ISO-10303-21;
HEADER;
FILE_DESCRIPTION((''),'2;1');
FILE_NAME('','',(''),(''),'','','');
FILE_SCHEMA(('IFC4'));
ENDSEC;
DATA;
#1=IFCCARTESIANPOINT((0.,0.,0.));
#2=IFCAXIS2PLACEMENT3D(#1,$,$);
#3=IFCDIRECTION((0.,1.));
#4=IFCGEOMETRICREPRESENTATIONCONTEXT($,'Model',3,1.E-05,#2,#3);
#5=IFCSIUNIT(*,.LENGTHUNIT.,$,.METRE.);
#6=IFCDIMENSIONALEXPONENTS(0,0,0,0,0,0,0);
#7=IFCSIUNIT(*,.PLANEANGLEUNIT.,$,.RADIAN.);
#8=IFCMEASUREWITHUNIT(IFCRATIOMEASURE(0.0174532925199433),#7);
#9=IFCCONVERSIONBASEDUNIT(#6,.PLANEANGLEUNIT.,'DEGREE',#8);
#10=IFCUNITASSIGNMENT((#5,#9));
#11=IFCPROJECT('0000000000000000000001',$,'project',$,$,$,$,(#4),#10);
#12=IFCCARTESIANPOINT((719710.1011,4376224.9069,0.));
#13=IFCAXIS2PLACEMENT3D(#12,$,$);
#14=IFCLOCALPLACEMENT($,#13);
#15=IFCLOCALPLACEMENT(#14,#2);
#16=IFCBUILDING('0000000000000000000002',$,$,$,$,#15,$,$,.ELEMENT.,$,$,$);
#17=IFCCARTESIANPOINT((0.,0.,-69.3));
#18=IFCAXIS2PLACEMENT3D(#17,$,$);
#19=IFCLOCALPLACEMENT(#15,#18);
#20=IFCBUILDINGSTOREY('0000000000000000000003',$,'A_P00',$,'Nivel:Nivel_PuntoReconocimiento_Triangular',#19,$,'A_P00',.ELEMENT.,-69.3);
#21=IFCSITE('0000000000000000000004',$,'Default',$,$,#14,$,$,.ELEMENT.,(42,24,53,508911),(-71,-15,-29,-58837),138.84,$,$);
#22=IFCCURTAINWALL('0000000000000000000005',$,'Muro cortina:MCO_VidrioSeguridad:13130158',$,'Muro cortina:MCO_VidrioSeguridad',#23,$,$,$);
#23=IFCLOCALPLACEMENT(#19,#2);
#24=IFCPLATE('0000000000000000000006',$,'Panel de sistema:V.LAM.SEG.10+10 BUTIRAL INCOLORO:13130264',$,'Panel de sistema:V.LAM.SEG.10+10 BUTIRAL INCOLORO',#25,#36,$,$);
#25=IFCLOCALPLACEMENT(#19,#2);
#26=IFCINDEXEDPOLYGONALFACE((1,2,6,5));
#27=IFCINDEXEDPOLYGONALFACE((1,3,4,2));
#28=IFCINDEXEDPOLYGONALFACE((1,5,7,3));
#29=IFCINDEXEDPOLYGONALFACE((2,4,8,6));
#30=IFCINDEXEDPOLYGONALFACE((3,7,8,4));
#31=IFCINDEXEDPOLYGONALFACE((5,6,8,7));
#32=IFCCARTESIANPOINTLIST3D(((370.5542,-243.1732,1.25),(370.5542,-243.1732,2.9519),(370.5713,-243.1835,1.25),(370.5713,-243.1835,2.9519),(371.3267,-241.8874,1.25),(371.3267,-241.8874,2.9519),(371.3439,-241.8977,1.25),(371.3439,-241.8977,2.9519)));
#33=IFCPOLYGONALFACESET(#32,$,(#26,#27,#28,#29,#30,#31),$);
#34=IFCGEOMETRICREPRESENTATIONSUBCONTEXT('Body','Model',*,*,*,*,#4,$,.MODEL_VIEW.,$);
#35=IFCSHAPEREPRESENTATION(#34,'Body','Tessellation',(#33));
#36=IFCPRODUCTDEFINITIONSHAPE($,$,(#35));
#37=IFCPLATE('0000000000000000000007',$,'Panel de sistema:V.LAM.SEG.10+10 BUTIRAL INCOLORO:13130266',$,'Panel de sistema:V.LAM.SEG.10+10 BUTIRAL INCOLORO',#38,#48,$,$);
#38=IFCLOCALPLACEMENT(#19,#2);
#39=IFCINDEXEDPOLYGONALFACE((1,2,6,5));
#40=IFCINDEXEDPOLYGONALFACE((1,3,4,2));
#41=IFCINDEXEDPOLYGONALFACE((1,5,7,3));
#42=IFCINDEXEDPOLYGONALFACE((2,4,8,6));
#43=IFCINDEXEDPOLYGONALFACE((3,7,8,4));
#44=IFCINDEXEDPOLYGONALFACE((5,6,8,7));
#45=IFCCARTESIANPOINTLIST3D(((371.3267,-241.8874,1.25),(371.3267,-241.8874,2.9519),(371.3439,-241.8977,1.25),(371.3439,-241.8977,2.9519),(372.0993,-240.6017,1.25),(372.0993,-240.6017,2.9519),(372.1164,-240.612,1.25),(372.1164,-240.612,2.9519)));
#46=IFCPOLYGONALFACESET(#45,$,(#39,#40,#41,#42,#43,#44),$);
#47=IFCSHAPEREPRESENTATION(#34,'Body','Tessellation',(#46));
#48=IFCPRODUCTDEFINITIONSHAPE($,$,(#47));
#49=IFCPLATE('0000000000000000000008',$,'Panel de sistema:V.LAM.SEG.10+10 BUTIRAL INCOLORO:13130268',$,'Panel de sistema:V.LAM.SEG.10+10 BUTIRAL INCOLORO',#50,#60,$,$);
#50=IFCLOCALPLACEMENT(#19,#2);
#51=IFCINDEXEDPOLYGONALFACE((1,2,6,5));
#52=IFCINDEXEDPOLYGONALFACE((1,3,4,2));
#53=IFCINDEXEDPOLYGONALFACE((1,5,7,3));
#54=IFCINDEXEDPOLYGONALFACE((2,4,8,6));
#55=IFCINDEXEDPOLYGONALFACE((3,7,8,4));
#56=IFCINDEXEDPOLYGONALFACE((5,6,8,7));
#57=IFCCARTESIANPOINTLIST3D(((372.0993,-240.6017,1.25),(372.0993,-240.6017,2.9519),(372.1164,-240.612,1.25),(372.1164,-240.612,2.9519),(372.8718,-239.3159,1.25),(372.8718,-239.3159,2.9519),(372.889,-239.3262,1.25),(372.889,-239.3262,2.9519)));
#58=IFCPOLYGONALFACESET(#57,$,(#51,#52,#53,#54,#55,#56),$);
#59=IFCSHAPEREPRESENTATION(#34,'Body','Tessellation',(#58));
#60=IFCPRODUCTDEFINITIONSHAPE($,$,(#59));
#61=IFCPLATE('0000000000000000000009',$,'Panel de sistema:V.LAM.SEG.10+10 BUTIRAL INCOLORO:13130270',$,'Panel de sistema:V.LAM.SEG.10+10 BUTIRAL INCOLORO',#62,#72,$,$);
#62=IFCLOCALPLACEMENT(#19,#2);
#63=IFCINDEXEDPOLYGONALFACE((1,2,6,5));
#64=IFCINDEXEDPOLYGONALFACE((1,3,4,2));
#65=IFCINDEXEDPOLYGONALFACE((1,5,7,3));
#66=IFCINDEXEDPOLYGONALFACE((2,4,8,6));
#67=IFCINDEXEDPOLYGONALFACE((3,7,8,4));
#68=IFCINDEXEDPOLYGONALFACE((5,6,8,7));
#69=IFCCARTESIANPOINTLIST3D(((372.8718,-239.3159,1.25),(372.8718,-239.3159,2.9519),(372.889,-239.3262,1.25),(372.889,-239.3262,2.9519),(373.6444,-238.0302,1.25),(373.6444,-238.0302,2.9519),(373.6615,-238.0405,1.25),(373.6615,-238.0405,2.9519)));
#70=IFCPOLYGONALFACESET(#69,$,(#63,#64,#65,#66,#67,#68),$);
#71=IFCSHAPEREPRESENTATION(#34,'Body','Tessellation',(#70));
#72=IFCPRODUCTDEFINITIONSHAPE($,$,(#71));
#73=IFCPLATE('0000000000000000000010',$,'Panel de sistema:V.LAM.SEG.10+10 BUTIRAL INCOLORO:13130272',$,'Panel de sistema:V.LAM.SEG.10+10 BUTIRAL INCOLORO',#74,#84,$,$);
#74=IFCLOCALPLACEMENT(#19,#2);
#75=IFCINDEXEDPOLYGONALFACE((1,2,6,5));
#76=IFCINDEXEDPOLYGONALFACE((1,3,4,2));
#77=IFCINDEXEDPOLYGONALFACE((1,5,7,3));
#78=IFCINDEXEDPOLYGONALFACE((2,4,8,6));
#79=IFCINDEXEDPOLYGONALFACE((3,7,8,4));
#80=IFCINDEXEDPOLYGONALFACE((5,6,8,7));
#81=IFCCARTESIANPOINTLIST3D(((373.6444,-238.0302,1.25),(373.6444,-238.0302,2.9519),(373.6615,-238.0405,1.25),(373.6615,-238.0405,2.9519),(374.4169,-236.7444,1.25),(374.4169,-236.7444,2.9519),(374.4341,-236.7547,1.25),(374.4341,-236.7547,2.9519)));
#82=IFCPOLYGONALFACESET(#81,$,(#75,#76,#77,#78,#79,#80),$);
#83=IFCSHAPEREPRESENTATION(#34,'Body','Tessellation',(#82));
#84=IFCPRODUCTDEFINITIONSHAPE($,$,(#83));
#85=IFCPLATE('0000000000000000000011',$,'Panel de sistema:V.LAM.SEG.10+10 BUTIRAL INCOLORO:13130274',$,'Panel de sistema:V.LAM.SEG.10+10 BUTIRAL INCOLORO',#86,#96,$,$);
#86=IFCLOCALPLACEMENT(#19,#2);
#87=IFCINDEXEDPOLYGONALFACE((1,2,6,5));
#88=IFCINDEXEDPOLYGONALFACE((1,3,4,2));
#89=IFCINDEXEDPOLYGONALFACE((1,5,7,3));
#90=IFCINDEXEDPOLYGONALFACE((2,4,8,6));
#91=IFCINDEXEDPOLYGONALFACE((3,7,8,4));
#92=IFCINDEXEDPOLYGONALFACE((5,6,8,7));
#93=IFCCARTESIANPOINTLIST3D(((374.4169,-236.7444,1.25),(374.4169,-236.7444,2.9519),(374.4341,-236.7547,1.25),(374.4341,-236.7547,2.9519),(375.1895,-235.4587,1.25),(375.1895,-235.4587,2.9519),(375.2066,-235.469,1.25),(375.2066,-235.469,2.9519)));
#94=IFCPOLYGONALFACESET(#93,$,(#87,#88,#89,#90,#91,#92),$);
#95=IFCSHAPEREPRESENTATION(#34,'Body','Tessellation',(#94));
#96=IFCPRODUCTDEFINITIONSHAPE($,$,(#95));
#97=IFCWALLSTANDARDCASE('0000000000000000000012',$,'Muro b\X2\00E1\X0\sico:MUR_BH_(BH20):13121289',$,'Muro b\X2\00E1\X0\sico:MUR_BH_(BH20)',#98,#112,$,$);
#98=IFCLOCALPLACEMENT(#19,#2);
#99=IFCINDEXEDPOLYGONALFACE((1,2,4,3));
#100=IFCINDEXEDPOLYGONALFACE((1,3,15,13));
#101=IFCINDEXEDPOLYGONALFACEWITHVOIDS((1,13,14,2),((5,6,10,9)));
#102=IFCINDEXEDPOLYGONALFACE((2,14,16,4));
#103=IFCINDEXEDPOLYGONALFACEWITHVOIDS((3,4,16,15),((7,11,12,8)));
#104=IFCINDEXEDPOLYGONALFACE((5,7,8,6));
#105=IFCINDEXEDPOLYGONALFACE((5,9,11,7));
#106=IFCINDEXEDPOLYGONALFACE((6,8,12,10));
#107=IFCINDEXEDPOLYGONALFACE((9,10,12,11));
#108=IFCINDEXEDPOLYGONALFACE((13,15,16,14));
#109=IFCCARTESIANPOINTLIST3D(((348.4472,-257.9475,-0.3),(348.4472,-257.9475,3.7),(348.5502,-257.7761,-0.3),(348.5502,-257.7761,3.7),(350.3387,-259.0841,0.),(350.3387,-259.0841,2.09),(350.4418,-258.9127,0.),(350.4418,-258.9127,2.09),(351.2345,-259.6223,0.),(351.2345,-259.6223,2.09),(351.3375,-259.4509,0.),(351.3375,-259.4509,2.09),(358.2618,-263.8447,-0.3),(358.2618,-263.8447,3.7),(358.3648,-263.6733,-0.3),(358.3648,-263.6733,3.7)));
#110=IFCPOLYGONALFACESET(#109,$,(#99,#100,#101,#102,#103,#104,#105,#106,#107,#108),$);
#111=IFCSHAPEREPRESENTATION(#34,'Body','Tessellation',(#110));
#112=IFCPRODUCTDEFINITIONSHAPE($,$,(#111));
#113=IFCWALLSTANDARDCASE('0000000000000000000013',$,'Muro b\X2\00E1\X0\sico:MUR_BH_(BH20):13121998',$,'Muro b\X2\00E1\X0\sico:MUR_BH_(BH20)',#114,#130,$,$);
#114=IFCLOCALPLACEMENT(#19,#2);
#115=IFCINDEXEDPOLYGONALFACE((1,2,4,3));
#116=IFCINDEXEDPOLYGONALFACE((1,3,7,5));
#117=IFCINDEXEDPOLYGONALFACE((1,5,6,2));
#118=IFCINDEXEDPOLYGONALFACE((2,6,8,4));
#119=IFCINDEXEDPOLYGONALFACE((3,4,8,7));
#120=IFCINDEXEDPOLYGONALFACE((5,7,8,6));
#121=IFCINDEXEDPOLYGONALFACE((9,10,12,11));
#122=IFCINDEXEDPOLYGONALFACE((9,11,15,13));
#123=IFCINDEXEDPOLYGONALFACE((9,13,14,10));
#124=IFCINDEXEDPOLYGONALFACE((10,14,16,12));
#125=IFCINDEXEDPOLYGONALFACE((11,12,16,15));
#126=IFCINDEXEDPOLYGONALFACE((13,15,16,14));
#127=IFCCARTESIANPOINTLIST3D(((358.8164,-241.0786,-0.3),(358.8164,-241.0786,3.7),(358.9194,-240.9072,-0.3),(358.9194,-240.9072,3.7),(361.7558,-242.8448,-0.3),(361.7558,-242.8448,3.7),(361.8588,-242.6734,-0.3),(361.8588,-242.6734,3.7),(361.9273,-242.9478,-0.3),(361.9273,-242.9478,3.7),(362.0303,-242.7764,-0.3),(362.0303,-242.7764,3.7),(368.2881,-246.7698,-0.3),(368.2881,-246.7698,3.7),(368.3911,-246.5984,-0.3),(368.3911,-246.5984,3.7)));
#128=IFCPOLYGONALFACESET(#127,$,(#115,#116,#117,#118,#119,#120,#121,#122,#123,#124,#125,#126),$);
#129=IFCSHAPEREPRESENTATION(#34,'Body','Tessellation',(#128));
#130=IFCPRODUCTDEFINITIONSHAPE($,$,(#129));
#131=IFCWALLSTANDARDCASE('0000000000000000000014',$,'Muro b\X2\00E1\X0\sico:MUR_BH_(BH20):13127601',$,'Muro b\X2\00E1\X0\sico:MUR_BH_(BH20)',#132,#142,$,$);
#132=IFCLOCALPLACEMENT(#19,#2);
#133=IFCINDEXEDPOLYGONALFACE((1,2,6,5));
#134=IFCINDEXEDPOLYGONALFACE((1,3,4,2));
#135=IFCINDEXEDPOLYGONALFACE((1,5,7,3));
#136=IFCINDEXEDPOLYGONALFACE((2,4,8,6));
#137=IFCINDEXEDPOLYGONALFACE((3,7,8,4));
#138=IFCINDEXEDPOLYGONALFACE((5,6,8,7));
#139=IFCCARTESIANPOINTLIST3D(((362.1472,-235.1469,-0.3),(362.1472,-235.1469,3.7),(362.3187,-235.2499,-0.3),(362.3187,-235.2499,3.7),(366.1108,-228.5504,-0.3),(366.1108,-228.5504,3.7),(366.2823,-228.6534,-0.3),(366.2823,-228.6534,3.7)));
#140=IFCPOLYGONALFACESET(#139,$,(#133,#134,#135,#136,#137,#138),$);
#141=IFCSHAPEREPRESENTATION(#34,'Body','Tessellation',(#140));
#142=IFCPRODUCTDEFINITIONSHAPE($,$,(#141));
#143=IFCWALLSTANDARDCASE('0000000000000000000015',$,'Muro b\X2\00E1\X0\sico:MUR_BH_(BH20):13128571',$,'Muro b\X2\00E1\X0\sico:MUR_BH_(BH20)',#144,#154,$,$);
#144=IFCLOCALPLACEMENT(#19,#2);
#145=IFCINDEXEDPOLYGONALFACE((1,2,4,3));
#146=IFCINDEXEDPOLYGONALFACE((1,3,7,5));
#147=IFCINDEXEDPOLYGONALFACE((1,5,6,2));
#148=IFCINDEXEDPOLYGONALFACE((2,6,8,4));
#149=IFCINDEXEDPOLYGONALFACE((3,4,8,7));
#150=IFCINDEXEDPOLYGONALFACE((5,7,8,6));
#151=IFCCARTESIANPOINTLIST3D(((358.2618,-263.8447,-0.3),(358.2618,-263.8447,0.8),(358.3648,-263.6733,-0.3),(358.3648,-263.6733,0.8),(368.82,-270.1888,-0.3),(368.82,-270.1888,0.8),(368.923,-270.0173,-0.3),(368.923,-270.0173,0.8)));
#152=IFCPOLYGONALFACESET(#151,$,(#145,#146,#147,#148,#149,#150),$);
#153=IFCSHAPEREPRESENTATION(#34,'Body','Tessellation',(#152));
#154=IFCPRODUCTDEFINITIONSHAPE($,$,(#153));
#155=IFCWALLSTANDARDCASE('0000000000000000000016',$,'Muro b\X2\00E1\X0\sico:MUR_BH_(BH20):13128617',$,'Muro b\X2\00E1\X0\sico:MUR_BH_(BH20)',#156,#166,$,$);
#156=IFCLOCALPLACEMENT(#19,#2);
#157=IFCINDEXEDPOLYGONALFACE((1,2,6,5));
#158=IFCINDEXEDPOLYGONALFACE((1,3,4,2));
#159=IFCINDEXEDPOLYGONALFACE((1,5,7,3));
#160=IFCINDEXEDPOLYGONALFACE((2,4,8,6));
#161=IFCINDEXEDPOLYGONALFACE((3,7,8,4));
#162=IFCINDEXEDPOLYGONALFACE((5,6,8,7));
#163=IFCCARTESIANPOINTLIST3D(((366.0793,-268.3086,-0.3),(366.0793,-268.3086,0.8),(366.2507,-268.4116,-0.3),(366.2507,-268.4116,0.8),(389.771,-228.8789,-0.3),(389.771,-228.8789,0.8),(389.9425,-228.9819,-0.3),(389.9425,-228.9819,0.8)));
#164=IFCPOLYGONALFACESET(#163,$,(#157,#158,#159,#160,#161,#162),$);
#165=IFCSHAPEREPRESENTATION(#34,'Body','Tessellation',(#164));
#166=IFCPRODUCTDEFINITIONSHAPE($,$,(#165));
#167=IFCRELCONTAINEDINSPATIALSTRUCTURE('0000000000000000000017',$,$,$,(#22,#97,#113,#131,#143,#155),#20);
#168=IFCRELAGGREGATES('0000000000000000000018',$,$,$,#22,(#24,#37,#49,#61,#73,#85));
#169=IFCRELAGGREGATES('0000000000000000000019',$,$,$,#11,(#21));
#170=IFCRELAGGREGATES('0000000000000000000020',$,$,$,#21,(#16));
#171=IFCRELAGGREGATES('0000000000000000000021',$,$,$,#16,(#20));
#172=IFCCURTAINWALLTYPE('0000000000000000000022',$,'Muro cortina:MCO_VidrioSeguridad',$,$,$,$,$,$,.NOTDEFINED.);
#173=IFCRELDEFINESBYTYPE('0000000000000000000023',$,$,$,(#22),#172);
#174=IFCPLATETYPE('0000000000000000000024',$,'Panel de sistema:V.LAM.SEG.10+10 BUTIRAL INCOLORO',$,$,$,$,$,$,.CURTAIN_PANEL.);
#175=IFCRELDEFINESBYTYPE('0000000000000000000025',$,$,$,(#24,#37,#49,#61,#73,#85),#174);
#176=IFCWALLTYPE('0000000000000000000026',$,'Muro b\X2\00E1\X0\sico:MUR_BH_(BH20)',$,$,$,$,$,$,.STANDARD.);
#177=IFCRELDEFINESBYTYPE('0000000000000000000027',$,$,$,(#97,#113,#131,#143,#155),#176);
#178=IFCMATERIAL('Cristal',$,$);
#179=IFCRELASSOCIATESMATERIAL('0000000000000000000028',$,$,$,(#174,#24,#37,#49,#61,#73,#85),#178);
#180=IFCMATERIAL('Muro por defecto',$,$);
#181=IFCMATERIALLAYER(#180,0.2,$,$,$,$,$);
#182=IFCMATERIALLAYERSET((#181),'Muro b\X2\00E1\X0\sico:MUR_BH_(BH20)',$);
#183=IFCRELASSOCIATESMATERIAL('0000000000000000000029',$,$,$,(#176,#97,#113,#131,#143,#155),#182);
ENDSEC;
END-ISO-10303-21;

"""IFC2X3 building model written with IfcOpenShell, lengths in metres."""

from ifc_helpers import new_model, entity, si_unit, converted_unit, direction, frame, frame_2d, origin, place, context, subcontext, project, spatial, rectangle, extrude, source, transform, mapped, material, layer, layer_set, layer_usage, type_object, type_shapes, element, aggregate, save


model = new_model("IFC2X3")

# Units and contexts
model_context = context("Model", 3, precision=1e-05, world=origin(), true_north=direction((0.0, 1.0)))
body_context = subcontext(model_context, "Body", "Model", "MODEL_VIEW")
ifc_project = project(units=[si_unit("LENGTHUNIT", "METRE"), converted_unit("PLANEANGLEUNIT", "DEGREE", entity("IfcRatioMeasure", 0.0174532925199433), si_unit("PLANEANGLEUNIT", "RADIAN"), dimensions=[0, 0, 0, 0, 0, 0, 0])], contexts=[model_context])

# Site, building, storey
site_placement = place(None, frame((719710.1011, 4376224.9069, 0.0)))
site = spatial("IfcSite", under=ifc_project, at=site_placement, Name="Default", CompositionType="ELEMENT", RefLatitude=(42, 24, 53, 508911), RefLongitude=(-71, -15, -29, -58837), RefElevation=138.84)
building_placement = place(site_placement, origin())
building = spatial("IfcBuilding", under=site, at=building_placement, CompositionType="ELEMENT")
storey_placement = place(building_placement, frame((0.0, 0.0, -69.3)))
storey = spatial("IfcBuildingStorey", under=building, at=storey_placement, Name="A_P00", ObjectType="Nivel:Nivel_PuntoReconocimiento_Triangular", LongName="A_P00", CompositionType="ELEMENT", Elevation=-69.3)

# Curtain wall, plates
curtain_wall_type = type_object("IfcCurtainWallType", Name="Muro cortina:MCO_VidrioSeguridad", PredefinedType="NOTDEFINED")
curtain_wall_placement = place(storey_placement, frame((0.0, 0.0, 69.3)))
curtain_wall = element("IfcCurtainWall", 1, at=curtain_wall_placement, inside=storey, type_object=curtain_wall_type, Name="Muro cortina:MCO_VidrioSeguridad:13130158", ObjectType="Muro cortina:MCO_VidrioSeguridad")
ifc_material_1 = material(Name="Cristal")
plate_type = type_object("IfcPlateType", Name="Panel de sistema:V.LAM.SEG.10+10 BUTIRAL INCOLORO", PredefinedType="CURTAIN_PANEL", material=ifc_material_1)
shared_shape = source(origin(), body_context, "Body", "SweptSolid", [
    extrude(rectangle(XDim=0.02, YDim=1.5, at=frame_2d((0.0, 0.0), x_axis=(1.0, 0.0))), frame((0.0, 0.0, 0.0), z_axis=(0.0, 0.0, 1.0), x_axis=(0.0, 1.0, 0.0)), (0.0, 0.0, 1.0), 1.7019),
])
type_shapes(plate_type, [shared_shape])
plate_1_placement = place(curtain_wall_placement, frame((370.949, -242.5355, -68.05), z_axis=(0.0, 0.0, 1.0), x_axis=(0.515038, 0.857167, 0.0)))
plate_1 = element("IfcPlate", 2, at=plate_1_placement, type_object=plate_type, material=ifc_material_1, Name="Panel de sistema:V.LAM.SEG.10+10 BUTIRAL INCOLORO:13130264", ObjectType="Panel de sistema:V.LAM.SEG.10+10 BUTIRAL INCOLORO", context=body_context, shape_type="MappedRepresentation", body=[
    mapped(shared_shape, transform((0.0, 0.0, 0.0), scale=1.0)),
])
plate_2_placement = place(curtain_wall_placement, frame((371.7216, -241.2497, -68.05), z_axis=(0.0, 0.0, 1.0), x_axis=(0.515038, 0.857167, 0.0)))
plate_2 = element("IfcPlate", 3, at=plate_2_placement, type_object=plate_type, material=ifc_material_1, Name="Panel de sistema:V.LAM.SEG.10+10 BUTIRAL INCOLORO:13130266", ObjectType="Panel de sistema:V.LAM.SEG.10+10 BUTIRAL INCOLORO", context=body_context, shape_type="MappedRepresentation", body=[
    mapped(shared_shape, transform((0.0, 0.0, 0.0), scale=1.0)),
])
plate_3_placement = place(curtain_wall_placement, frame((372.4941, -239.964, -68.05), z_axis=(0.0, 0.0, 1.0), x_axis=(0.515038, 0.857167, 0.0)))
plate_3 = element("IfcPlate", 4, at=plate_3_placement, type_object=plate_type, material=ifc_material_1, Name="Panel de sistema:V.LAM.SEG.10+10 BUTIRAL INCOLORO:13130268", ObjectType="Panel de sistema:V.LAM.SEG.10+10 BUTIRAL INCOLORO", context=body_context, shape_type="MappedRepresentation", body=[
    mapped(shared_shape, transform((0.0, 0.0, 0.0), scale=1.0)),
])
plate_4_placement = place(curtain_wall_placement, frame((373.2667, -238.6782, -68.05), z_axis=(0.0, 0.0, 1.0), x_axis=(0.515038, 0.857167, 0.0)))
plate_4 = element("IfcPlate", 5, at=plate_4_placement, type_object=plate_type, material=ifc_material_1, Name="Panel de sistema:V.LAM.SEG.10+10 BUTIRAL INCOLORO:13130270", ObjectType="Panel de sistema:V.LAM.SEG.10+10 BUTIRAL INCOLORO", context=body_context, shape_type="MappedRepresentation", body=[
    mapped(shared_shape, transform((0.0, 0.0, 0.0), scale=1.0)),
])
plate_5_placement = place(curtain_wall_placement, frame((374.0392, -237.3925, -68.05), z_axis=(0.0, 0.0, 1.0), x_axis=(0.515038, 0.857167, 0.0)))
plate_5 = element("IfcPlate", 6, at=plate_5_placement, type_object=plate_type, material=ifc_material_1, Name="Panel de sistema:V.LAM.SEG.10+10 BUTIRAL INCOLORO:13130272", ObjectType="Panel de sistema:V.LAM.SEG.10+10 BUTIRAL INCOLORO", context=body_context, shape_type="MappedRepresentation", body=[
    mapped(shared_shape, transform((0.0, 0.0, 0.0), scale=1.0)),
])
plate_6_placement = place(curtain_wall_placement, frame((374.8118, -236.1067, -68.05), z_axis=(0.0, 0.0, 1.0), x_axis=(0.515038, 0.857167, 0.0)))
plate_6 = element("IfcPlate", 7, at=plate_6_placement, type_object=plate_type, material=ifc_material_1, Name="Panel de sistema:V.LAM.SEG.10+10 BUTIRAL INCOLORO:13130274", ObjectType="Panel de sistema:V.LAM.SEG.10+10 BUTIRAL INCOLORO", context=body_context, shape_type="MappedRepresentation", body=[
    mapped(shared_shape, transform((0.0, 0.0, 0.0), scale=1.0)),
])
aggregate(curtain_wall, [plate_1, plate_2, plate_3, plate_4, plate_5, plate_6])

# Walls, openings
ifc_material_2 = material(Name="Muro por defecto")
ifc_layer = layer(ifc_material_2, 0.2)
ifc_layer_set = layer_set([ifc_layer], Name="Muro básico:MUR_BH_(BH20)")
ifc_layer_usage_1 = layer_usage(ifc_layer_set, "AXIS2", "NEGATIVE", 0.1)
wall_type = type_object("IfcWallType", Name="Muro básico:MUR_BH_(BH20)", PredefinedType="STANDARD", material=ifc_layer_set)
wall_1_placement = place(storey_placement, frame((358.3133, -263.759, -0.3), z_axis=(0.0, 0.0, 1.0), x_axis=(-0.857167, 0.515038, 0.0)))
wall_1 = element("IfcWallStandardCase", 8, at=wall_1_placement, inside=storey, type_object=wall_type, material=ifc_layer_usage_1, Name="Muro básico:MUR_BH_(BH20):13121289", ObjectType="Muro básico:MUR_BH_(BH20)", context=body_context, shape_type="SweptSolid", body=[
    extrude(rectangle(XDim=11.45, YDim=0.2, at=frame_2d((5.725, 0.0), x_axis=(-1.0, 0.0))), origin(), (0.0, 0.0, 1.0), 4.0),
])
opening_1_placement = place(wall_1_placement, frame((442.9804, -41.5406, 0.3), z_axis=(0.0, 0.0, 1.0), x_axis=(-0.857167, -0.515038, 0.0)))
element("IfcOpeningElement", 9, at=opening_1_placement, cuts=wall_1, ObjectType="Opening", context=body_context, shape_type="SweptSolid", body=[
    extrude(rectangle(XDim=2.09, YDim=1.045, at=frame_2d((0.0, 0.0), x_axis=(0.0, 1.0))), frame((350.8896, -259.1818, 1.045), z_axis=(-0.515038, -0.857167, 0.0), x_axis=(-0.857167, 0.515038, 0.0)), (0.0, 0.0, 1.0), 0.2),
])
ifc_layer_usage_2 = layer_usage(ifc_layer_set, "AXIS2", "NEGATIVE", 0.1)
wall_2_placement = place(storey_placement, frame((358.8679, -240.9929, -0.3), z_axis=(0.0, 0.0, 1.0), x_axis=(0.857167, -0.515038, 0.0)))
wall_2 = element("IfcWallStandardCase", 10, at=wall_2_placement, inside=storey, type_object=wall_type, material=ifc_layer_usage_2, Name="Muro básico:MUR_BH_(BH20):13121998", ObjectType="Muro básico:MUR_BH_(BH20)", context=body_context, shape_type="SweptSolid", body=[
    extrude(rectangle(XDim=11.05, YDim=0.2, at=frame_2d((5.525, 0.0), x_axis=(-1.0, 0.0))), origin(), (0.0, 0.0, 1.0), 4.0),
])
opening_2_placement = place(storey_placement, frame((358.8679, -240.9929, -0.3), z_axis=(0.0, 0.0, 1.0), x_axis=(0.857167, -0.515038, 0.0)))
element("IfcOpeningElement", 11, at=opening_2_placement, cuts=wall_2, ObjectType="Opening", context=body_context, shape_type="SweptSolid", body=[
    extrude(rectangle(XDim=4.0, YDim=0.2, at=frame_2d((0.0, 0.0), x_axis=(1.0, 0.0))), frame((3.4292, 0.0, 2.0), z_axis=(1.0, 0.0, 0.0), x_axis=(0.0, 0.0, -1.0)), (0.0, 0.0, 1.0), 0.2),
])

# Walls
ifc_layer_usage_3 = layer_usage(ifc_layer_set, "AXIS2", "NEGATIVE", 0.1)
wall_3_placement = place(storey_placement, frame((362.2329, -235.1984, -0.3), z_axis=(0.0, 0.0, 1.0), x_axis=(0.515038, 0.857167, 0.0)))
element("IfcWallStandardCase", 12, at=wall_3_placement, inside=storey, type_object=wall_type, material=ifc_layer_usage_3, Name="Muro básico:MUR_BH_(BH20):13127601", ObjectType="Muro básico:MUR_BH_(BH20)", context=body_context, shape_type="SweptSolid", body=[
    extrude(rectangle(XDim=7.6957, YDim=0.2, at=frame_2d((3.8479, 0.0), x_axis=(-1.0, 0.0))), origin(), (0.0, 0.0, 1.0), 4.0),
])
ifc_layer_usage_4 = layer_usage(ifc_layer_set, "AXIS2", "NEGATIVE", 0.1)
wall_4_placement = place(storey_placement, frame((358.3133, -263.759, -0.3), z_axis=(0.0, 0.0, 1.0), x_axis=(0.857167, -0.515038, 0.0)))
element("IfcWallStandardCase", 13, at=wall_4_placement, inside=storey, type_object=wall_type, material=ifc_layer_usage_4, Name="Muro básico:MUR_BH_(BH20):13128571", ObjectType="Muro básico:MUR_BH_(BH20)", context=body_context, shape_type="SweptSolid", body=[
    extrude(rectangle(XDim=12.3176, YDim=0.2, at=frame_2d((6.1588, 0.0), x_axis=(-1.0, 0.0))), origin(), (0.0, 0.0, 1.0), 1.1),
])
ifc_layer_usage_5 = layer_usage(ifc_layer_set, "AXIS2", "POSITIVE", -0.1)
wall_5_placement = place(storey_placement, frame((366.165, -268.3601, -0.3), z_axis=(0.0, 0.0, 1.0), x_axis=(0.515038, 0.857167, 0.0)))
element("IfcWallStandardCase", 14, at=wall_5_placement, inside=storey, type_object=wall_type, material=ifc_layer_usage_5, Name="Muro básico:MUR_BH_(BH20):13128617", ObjectType="Muro básico:MUR_BH_(BH20)", context=body_context, shape_type="SweptSolid", body=[
    extrude(rectangle(XDim=46.0, YDim=0.2, at=frame_2d((23.0, 0.0), x_axis=(-1.0, 0.0))), origin(), (0.0, 0.0, 1.0), 1.1),
])

save(model, "model.ifc")
